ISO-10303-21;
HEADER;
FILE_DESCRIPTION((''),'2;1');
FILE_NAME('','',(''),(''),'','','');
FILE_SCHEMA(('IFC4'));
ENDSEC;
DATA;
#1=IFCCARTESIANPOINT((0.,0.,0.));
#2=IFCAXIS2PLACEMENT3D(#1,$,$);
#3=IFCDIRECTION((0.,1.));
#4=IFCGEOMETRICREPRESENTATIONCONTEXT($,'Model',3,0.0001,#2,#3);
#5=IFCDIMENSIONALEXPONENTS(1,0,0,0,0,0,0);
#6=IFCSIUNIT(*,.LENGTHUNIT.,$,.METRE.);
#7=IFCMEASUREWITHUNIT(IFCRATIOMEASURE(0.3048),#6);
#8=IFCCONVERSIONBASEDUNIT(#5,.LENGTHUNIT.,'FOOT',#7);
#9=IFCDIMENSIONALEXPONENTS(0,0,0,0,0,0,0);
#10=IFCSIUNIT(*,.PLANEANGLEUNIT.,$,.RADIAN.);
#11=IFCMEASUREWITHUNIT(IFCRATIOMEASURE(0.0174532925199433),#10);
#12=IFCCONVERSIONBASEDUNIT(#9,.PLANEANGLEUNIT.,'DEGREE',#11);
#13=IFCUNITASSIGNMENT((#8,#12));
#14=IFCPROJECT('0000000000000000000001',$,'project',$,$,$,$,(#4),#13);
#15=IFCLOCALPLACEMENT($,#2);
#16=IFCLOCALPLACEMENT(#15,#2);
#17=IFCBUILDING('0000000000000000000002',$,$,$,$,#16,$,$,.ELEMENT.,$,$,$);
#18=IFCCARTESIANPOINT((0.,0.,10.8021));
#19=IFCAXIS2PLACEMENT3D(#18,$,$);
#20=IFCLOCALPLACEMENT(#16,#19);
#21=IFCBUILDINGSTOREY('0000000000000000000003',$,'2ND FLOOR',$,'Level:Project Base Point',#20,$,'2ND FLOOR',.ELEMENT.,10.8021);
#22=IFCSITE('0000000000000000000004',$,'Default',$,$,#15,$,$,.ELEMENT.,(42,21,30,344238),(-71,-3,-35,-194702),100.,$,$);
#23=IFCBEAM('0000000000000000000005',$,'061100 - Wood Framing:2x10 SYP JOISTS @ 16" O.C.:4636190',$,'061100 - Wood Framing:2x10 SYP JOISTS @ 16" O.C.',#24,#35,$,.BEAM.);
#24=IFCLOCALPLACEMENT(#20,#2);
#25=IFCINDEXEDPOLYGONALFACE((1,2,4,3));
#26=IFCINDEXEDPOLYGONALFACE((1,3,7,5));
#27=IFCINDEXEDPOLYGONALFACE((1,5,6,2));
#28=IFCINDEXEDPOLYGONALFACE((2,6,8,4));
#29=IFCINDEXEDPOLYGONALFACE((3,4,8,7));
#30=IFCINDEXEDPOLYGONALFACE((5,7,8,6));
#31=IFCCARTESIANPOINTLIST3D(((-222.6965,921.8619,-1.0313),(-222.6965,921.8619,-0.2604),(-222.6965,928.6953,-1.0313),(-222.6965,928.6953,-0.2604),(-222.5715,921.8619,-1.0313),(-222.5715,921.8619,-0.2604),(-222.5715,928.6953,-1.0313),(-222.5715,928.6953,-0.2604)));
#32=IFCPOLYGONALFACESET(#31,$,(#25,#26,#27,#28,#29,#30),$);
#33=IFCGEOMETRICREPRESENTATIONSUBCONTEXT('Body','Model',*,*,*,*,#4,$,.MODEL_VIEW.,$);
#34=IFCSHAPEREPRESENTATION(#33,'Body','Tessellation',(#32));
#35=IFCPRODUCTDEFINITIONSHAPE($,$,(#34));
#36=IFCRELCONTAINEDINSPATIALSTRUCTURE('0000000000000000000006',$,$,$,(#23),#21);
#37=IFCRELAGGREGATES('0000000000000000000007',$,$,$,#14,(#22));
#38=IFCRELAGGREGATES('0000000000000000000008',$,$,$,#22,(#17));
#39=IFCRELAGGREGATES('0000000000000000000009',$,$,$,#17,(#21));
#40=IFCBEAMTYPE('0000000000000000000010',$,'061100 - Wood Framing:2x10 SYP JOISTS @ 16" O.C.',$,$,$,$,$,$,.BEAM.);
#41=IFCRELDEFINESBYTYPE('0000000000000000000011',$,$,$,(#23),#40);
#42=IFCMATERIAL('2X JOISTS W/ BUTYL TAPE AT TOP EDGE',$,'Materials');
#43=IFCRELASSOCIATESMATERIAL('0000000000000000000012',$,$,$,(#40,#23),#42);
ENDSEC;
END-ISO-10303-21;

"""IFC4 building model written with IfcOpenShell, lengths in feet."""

from ifc_helpers import new_model, entity, si_unit, converted_unit, direction, frame, frame_2d, origin, origin_2d_with_axis, place, context, subcontext, project, spatial, rectangle, extrude, source, transform, mapped, material, material_profile, profile_set, profile_usage, type_object, type_shapes, element, save


model = new_model("IFC4")

# Units and contexts
model_context = context("Model", 3, precision=0.0001, world=origin(), true_north=direction((0.0, 1.0)))
body_context = subcontext(model_context, "Body", "Model", "MODEL_VIEW")
ifc_project = project(units=[converted_unit("LENGTHUNIT", "FOOT", entity("IfcRatioMeasure", 0.3048), si_unit("LENGTHUNIT", "METRE"), dimensions=[1, 0, 0, 0, 0, 0, 0]), converted_unit("PLANEANGLEUNIT", "DEGREE", entity("IfcRatioMeasure", 0.0174532925199433), si_unit("PLANEANGLEUNIT", "RADIAN"), dimensions=[0, 0, 0, 0, 0, 0, 0])], contexts=[model_context])

# Site, building, storey
site_placement = place(None, origin())
site = spatial("IfcSite", under=ifc_project, at=site_placement, Name="Default", CompositionType="ELEMENT", RefLatitude=(42, 21, 30, 344238), RefLongitude=(-71, -3, -35, -194702), RefElevation=100.0)
building_placement = place(site_placement, origin())
building = spatial("IfcBuilding", under=site, at=building_placement, CompositionType="ELEMENT")
storey_placement = place(building_placement, frame((0.0, 0.0, 10.8021)))
storey = spatial("IfcBuildingStorey", under=building, at=storey_placement, Name="2ND FLOOR", ObjectType="Level:Project Base Point", LongName="2ND FLOOR", CompositionType="ELEMENT", Elevation=10.8021)

# Shared definitions
ifc_material_1 = material(Name="2X JOISTS W/ BUTYL TAPE AT TOP EDGE", Category="Materials")
ifc_material_profile_1 = material_profile(ifc_material_1, rectangle(XDim=0.7708, YDim=0.125, at=frame_2d((0.0, 0.0), x_axis=(1.0, 0.0))), Name="2x10 SYP JOISTS @ 16\" O.C.")
ifc_profile_set_1 = profile_set([ifc_material_profile_1], Name="2x10 SYP JOISTS @ 16\" O.C.")

# Beam
ifc_profile_usage_1 = profile_usage(ifc_profile_set_1, cardinal=8)
beam_type_1 = type_object("IfcBeamType", Name="061100 - Wood Framing:2x10 SYP JOISTS @ 16\" O.C.", PredefinedType="BEAM", material=ifc_profile_set_1)
shared_shape_1 = source(origin(), body_context, "Body", "SweptSolid", [
    extrude(rectangle(XDim=0.7708, YDim=0.125, at=origin_2d_with_axis()), frame((-3.4792, 0.0, 0.0), z_axis=(1.0, 0.0, 0.0), x_axis=(0.0, 0.0, -1.0)), (0.0, 0.0, 1.0), 6.8333),
])
type_shapes(beam_type_1, [shared_shape_1])
beam_1_placement = place(storey_placement, frame((-222.634, 925.3411, -0.6458), z_axis=(0.0, 0.0, 1.0), x_axis=(0.0, 1.0, 0.0)))
element("IfcBeam", 1, at=beam_1_placement, inside=storey, type_object=beam_type_1, material=ifc_profile_usage_1, Name="061100 - Wood Framing:2x10 SYP JOISTS @ 16\" O.C.:4636190", ObjectType="061100 - Wood Framing:2x10 SYP JOISTS @ 16\" O.C.", PredefinedType="BEAM", context=body_context, shape_type="MappedRepresentation", body=[
    mapped(shared_shape_1, transform((0.0, 0.0, 0.0), scale=1.0)),
])

save(model, "model.ifc")
